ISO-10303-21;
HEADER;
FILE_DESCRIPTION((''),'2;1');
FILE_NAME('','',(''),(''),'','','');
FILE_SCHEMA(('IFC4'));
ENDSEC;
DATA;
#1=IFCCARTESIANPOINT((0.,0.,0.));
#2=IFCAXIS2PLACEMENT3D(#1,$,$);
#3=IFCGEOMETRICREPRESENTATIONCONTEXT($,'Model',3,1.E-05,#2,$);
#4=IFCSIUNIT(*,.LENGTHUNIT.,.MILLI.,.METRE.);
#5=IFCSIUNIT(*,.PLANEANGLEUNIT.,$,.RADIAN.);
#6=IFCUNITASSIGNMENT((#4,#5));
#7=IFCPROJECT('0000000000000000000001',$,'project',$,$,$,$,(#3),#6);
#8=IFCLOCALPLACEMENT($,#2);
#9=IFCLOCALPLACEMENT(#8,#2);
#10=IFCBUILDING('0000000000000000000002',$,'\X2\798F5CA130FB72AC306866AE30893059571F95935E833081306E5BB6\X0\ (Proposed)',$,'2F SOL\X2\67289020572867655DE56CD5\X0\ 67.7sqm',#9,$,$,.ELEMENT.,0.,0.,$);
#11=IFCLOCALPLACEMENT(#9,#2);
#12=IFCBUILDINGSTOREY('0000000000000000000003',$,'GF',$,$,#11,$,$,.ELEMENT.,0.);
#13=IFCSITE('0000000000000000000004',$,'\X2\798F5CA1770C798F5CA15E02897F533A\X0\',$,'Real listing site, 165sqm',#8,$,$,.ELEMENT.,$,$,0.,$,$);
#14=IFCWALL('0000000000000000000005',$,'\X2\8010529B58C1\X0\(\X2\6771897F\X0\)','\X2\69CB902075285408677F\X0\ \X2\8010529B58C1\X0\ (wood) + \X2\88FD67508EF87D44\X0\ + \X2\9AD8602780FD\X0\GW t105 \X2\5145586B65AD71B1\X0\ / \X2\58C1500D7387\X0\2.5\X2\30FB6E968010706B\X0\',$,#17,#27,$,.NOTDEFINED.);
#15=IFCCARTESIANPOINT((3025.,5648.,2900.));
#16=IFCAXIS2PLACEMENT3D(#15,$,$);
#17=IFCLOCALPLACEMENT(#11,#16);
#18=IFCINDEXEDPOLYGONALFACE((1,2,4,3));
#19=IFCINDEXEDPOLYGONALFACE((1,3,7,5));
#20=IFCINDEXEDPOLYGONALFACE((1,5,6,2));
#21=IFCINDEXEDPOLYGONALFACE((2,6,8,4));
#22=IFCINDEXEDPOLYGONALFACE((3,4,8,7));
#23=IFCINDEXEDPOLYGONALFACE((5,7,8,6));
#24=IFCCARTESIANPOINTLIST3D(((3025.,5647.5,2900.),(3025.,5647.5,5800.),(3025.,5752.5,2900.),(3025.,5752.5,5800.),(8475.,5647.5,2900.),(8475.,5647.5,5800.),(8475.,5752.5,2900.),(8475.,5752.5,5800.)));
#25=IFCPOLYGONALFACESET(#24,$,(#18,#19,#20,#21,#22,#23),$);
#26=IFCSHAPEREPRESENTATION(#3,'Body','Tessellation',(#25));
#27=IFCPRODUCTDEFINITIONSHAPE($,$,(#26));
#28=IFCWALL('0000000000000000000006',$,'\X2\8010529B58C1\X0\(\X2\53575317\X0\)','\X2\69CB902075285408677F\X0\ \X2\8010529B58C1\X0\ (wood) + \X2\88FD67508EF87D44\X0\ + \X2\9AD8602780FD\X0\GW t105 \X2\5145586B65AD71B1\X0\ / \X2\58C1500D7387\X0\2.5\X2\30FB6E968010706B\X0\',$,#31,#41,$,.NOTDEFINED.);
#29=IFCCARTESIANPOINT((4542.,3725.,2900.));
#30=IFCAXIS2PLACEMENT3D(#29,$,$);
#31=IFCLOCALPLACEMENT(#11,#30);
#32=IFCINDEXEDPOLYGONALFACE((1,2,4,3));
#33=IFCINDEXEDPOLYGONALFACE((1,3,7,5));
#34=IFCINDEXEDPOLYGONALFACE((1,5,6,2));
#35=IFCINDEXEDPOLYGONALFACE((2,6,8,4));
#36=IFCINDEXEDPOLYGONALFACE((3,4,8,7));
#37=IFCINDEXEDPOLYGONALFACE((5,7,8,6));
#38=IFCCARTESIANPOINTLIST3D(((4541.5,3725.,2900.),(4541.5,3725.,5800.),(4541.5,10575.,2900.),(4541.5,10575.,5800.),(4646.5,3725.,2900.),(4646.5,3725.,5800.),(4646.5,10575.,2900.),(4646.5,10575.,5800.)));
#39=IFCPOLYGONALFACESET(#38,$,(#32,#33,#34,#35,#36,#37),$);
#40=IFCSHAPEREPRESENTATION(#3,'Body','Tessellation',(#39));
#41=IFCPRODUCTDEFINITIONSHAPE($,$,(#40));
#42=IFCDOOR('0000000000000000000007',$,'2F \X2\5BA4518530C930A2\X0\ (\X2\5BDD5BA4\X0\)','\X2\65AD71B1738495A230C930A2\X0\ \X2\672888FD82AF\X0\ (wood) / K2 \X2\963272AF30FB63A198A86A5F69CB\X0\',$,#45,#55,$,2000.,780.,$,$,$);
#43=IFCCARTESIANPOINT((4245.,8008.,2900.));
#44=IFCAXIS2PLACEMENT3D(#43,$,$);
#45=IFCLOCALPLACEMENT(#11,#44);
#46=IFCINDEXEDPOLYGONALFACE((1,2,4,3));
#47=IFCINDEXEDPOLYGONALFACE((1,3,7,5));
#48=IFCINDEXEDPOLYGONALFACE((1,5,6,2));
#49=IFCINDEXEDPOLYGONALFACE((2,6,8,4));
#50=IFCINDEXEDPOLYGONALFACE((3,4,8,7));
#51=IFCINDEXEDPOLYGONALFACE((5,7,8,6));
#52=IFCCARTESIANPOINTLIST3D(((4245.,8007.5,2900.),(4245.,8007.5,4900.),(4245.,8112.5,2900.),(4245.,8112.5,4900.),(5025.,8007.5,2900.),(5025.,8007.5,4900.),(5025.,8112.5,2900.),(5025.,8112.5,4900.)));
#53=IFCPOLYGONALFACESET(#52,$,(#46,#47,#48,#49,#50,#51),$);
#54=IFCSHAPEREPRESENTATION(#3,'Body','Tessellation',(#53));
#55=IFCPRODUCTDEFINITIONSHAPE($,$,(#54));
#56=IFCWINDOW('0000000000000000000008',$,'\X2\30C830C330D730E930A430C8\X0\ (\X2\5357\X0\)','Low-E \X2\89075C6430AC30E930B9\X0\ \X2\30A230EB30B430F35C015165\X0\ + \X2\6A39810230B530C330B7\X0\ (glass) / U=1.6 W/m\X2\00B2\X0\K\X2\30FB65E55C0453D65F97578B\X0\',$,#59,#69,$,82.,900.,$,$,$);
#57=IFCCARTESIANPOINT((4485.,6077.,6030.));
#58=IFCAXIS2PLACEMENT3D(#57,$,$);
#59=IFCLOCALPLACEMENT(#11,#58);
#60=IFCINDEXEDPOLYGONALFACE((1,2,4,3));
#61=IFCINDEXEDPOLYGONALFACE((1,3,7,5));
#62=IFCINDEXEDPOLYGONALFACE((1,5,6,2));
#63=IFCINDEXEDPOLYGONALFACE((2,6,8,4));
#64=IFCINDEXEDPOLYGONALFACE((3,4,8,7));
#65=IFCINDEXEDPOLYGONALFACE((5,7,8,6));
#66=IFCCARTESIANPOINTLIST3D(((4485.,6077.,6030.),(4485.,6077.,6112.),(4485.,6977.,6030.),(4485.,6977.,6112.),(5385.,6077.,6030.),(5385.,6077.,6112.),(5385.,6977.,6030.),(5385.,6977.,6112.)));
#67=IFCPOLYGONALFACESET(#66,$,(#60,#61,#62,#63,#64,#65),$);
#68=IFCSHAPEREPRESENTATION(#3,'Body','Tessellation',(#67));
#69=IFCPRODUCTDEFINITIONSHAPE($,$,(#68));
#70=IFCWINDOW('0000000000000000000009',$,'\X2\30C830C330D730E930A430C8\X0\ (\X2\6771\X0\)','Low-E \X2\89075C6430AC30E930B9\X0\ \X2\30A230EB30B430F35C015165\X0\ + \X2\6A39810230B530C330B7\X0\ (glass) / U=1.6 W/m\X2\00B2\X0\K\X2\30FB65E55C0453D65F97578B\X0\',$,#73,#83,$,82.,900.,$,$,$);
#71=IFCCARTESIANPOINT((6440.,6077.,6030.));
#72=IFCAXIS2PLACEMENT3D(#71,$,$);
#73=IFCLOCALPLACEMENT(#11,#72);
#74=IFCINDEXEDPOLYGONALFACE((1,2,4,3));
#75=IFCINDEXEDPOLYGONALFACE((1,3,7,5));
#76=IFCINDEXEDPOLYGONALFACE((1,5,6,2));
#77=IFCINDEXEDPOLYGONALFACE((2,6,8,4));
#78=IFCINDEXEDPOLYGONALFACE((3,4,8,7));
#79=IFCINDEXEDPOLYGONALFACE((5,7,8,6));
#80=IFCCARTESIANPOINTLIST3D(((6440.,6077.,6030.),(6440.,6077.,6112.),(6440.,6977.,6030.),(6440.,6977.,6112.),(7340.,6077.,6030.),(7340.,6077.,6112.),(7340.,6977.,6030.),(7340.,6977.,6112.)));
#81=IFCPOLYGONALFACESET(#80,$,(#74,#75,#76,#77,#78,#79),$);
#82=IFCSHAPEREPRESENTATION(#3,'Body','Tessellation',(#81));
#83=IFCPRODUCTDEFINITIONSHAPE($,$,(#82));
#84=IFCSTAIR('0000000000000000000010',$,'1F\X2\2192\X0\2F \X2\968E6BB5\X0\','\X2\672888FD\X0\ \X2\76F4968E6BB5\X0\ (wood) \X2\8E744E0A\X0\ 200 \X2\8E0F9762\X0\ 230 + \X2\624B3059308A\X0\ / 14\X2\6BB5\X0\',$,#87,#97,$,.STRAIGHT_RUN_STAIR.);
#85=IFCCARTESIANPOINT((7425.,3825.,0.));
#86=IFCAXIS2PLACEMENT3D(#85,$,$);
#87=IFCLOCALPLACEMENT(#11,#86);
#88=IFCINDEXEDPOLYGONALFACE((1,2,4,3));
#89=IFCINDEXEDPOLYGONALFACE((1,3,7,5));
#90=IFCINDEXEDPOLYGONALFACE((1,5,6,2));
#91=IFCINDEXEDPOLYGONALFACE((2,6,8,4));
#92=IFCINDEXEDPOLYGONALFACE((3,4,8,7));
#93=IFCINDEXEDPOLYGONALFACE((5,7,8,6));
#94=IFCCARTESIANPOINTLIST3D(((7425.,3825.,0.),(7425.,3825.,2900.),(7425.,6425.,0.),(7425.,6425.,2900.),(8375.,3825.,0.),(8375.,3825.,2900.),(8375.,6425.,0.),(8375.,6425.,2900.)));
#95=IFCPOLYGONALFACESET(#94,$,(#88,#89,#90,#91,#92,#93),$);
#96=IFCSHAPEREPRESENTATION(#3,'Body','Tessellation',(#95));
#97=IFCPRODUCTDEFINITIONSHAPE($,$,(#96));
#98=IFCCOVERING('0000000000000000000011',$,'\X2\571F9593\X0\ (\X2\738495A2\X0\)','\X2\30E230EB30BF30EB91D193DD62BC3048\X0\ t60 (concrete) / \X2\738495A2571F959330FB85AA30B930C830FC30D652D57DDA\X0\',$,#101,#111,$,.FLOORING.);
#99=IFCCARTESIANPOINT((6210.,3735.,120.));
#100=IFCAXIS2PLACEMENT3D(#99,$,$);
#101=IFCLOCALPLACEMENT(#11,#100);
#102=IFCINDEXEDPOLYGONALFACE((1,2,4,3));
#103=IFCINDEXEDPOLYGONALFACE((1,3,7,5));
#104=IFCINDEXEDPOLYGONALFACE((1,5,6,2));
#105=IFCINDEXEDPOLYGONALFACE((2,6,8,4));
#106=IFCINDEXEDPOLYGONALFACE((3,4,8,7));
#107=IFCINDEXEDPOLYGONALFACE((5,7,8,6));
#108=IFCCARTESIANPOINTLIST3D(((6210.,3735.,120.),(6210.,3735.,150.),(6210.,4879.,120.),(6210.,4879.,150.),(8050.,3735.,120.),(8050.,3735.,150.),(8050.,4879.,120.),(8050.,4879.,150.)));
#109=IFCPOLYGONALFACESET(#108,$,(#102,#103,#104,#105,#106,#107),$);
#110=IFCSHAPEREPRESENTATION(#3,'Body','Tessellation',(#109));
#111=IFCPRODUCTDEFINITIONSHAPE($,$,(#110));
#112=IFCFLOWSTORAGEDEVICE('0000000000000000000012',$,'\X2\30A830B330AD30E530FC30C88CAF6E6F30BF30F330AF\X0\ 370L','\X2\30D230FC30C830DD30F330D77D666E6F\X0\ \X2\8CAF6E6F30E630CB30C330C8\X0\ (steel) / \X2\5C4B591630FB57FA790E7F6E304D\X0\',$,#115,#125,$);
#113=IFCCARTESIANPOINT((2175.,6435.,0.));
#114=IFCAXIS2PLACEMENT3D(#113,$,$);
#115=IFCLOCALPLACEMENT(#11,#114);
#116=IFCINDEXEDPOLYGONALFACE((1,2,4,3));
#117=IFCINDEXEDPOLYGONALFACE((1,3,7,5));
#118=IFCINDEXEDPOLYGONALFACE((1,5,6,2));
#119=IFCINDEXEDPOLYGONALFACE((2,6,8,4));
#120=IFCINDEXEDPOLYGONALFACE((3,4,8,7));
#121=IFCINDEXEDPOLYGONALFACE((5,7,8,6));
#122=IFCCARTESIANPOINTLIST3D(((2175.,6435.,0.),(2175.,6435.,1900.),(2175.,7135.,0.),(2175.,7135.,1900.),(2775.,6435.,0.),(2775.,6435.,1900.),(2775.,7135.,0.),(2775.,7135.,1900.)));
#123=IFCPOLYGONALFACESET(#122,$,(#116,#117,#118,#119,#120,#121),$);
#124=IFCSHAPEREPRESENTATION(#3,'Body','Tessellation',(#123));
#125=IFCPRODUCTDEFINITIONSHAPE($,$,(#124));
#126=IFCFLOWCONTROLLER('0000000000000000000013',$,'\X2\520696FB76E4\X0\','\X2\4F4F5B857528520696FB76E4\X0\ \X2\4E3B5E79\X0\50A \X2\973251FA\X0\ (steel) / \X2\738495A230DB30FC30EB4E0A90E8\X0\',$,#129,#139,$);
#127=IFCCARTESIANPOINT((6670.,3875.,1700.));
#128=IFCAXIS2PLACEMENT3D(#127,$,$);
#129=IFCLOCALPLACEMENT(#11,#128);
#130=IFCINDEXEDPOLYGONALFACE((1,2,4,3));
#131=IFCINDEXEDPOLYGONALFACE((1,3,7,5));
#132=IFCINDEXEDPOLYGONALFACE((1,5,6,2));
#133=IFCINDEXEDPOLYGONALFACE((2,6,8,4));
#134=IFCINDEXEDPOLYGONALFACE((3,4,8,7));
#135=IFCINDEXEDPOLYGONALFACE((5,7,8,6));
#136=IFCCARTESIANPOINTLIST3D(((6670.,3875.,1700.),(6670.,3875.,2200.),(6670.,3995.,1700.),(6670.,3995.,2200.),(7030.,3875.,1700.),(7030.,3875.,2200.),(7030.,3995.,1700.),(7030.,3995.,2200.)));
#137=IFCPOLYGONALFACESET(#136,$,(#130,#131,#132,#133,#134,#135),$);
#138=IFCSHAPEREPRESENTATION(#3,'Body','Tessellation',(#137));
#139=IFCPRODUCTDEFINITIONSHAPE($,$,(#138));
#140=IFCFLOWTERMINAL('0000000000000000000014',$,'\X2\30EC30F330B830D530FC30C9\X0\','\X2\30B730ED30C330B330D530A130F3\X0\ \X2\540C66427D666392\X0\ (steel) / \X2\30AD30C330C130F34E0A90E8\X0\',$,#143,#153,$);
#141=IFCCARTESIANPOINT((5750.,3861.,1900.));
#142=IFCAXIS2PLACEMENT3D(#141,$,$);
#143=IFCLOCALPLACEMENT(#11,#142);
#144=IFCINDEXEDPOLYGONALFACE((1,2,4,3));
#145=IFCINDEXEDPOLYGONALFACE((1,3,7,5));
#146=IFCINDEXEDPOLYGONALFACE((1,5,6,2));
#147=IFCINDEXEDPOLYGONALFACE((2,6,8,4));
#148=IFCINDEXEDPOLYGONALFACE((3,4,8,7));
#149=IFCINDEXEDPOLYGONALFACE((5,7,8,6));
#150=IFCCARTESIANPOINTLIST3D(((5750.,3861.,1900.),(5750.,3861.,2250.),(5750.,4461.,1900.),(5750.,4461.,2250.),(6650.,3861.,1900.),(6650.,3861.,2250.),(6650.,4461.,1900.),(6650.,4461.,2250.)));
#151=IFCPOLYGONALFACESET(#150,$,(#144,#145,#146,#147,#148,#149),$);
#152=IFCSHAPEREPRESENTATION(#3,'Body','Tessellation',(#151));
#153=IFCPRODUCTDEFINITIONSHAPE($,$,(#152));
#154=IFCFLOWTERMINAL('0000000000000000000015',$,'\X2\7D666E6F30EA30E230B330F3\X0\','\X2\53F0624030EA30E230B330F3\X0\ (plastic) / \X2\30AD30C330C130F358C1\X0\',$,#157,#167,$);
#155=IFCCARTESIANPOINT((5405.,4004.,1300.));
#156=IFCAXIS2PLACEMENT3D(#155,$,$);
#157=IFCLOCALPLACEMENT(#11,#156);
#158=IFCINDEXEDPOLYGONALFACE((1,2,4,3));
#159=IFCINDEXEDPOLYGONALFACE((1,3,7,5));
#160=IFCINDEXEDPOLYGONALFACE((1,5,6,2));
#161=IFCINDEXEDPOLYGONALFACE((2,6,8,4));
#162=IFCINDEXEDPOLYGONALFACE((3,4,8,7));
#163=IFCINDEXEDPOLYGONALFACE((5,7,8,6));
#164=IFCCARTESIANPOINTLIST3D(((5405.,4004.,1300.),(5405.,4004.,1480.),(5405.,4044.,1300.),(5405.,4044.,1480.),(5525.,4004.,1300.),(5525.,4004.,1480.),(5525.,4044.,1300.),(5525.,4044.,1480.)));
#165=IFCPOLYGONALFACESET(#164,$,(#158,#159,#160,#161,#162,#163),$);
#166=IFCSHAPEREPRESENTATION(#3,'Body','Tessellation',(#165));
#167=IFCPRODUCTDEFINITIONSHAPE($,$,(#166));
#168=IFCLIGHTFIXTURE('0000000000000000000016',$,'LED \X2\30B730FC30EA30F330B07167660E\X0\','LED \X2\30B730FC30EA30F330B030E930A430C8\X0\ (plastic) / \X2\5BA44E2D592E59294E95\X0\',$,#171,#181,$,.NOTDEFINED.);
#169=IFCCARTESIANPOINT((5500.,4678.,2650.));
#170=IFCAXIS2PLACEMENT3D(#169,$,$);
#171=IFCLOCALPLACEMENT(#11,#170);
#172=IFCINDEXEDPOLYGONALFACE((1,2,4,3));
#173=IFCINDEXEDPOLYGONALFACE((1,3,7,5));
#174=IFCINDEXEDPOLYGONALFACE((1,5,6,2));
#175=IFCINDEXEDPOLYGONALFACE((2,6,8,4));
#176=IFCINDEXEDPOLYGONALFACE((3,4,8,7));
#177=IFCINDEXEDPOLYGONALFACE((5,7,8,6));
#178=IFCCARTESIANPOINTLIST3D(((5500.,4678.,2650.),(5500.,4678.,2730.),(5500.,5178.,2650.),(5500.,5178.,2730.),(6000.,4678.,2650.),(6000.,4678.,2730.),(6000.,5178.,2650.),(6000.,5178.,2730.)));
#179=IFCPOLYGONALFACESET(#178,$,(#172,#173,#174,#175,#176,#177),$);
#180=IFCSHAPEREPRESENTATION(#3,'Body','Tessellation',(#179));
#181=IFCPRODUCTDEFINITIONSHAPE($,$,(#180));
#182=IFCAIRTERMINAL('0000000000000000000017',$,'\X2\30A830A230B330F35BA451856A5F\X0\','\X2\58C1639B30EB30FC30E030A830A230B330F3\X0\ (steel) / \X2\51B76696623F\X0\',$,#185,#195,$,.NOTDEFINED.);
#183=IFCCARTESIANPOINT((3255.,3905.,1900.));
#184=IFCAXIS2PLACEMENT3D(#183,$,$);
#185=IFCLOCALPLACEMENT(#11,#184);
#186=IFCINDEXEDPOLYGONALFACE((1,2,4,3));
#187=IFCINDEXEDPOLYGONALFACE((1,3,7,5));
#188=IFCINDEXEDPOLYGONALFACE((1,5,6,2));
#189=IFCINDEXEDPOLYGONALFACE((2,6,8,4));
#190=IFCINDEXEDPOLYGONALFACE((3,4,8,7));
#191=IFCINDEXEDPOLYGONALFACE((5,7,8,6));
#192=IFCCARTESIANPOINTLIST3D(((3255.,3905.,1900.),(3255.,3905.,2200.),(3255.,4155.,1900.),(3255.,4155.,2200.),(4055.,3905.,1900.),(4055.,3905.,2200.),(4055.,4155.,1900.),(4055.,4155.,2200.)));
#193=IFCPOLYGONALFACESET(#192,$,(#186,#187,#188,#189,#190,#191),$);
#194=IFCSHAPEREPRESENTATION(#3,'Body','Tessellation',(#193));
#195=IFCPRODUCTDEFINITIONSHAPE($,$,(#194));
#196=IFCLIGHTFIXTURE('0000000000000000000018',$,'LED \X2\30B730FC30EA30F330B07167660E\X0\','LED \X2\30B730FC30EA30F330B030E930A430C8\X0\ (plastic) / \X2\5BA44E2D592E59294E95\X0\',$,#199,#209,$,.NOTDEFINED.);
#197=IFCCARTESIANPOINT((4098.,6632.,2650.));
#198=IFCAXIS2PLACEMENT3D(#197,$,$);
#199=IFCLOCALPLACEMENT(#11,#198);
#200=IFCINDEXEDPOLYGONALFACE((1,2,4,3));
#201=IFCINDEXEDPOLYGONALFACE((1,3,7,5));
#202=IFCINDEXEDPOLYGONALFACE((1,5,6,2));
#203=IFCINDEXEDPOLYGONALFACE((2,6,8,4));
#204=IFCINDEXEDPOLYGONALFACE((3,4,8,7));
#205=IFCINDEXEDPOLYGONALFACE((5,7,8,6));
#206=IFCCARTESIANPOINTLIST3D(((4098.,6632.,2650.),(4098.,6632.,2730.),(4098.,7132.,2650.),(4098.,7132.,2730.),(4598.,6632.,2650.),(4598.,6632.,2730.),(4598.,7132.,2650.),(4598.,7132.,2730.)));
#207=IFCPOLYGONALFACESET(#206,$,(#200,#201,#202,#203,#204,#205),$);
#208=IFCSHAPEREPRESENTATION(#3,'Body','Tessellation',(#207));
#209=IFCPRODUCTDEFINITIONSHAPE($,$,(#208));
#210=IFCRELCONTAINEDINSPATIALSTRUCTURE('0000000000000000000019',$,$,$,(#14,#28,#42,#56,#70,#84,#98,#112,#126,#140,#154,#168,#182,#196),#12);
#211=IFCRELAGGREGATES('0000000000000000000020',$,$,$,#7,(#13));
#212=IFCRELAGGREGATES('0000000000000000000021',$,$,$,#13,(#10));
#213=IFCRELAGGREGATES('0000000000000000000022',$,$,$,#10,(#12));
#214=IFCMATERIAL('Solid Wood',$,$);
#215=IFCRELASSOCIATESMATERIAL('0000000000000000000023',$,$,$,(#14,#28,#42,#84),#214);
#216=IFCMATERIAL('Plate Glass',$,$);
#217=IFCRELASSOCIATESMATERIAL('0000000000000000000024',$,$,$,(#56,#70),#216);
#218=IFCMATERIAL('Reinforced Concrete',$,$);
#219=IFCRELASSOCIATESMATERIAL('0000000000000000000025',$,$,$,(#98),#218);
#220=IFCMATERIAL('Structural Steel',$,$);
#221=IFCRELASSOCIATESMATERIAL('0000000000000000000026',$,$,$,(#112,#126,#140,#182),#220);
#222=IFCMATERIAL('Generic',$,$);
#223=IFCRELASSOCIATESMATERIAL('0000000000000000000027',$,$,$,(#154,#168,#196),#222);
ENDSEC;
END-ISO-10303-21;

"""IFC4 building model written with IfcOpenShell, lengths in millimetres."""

from ifc_helpers import new_model, si_unit, frame, frame_2d, origin, place, context, project, spatial, rectangle, extrude, material, element, fill, save


model = new_model("IFC4")

# Units and contexts
model_context = context("Model", 3, precision=1e-05, world=origin())
ifc_project = project(units=[si_unit("LENGTHUNIT", "METRE", prefix="MILLI"), si_unit("PLANEANGLEUNIT", "RADIAN")], contexts=[model_context])

# Site, building, storey
site_placement = place(None, origin())
site = spatial("IfcSite", under=ifc_project, at=site_placement, Name="福岡県福岡市西区", ObjectType="Real listing site, 165sqm", CompositionType="ELEMENT", RefElevation=0.0)
building_placement = place(site_placement, origin())
building = spatial("IfcBuilding", under=site, at=building_placement, Name="福岡・犬と暮らす土間広めの家 (Proposed)", ObjectType="2F SOL木造在来工法 67.7sqm", CompositionType="ELEMENT", ElevationOfRefHeight=0.0, ElevationOfTerrain=0.0)
storey_placement = place(building_placement, origin())
storey = spatial("IfcBuildingStorey", under=building, at=storey_placement, Name="GF", CompositionType="ELEMENT", Elevation=0.0)

# Shared definitions
ifc_material_1 = material(Name="Solid Wood")

# Wall
wall_1_placement = place(storey_placement, frame((3025.0, 5648.0, 2900.0)))
element("IfcWall", 1, at=wall_1_placement, inside=storey, material=ifc_material_1, Name="耐力壁(東西)", Description="構造用合板 耐力壁 (wood) + 製材軸組 + 高性能GW t105 充填断熱 / 壁倍率2.5・準耐火", PredefinedType="NOTDEFINED", context=model_context, shape_type="SweptSolid", body=[
    extrude(rectangle(XDim=5450.0, YDim=105.0, at=frame_2d((2725.0, 52.0))), frame((3025.0, 5648.0, 2900.0)), (0.0, 0.0, 1.0), 2900.0),
])

# Wall, opening, door
wall_2_placement = place(storey_placement, frame((4542.0, 3725.0, 2900.0)))
wall_2 = element("IfcWall", 2, at=wall_2_placement, inside=storey, material=ifc_material_1, Name="耐力壁(南北)", Description="構造用合板 耐力壁 (wood) + 製材軸組 + 高性能GW t105 充填断熱 / 壁倍率2.5・準耐火", PredefinedType="NOTDEFINED", context=model_context, shape_type="SweptSolid", body=[
    extrude(rectangle(XDim=105.0, YDim=6850.0, at=frame_2d((52.0, 3425.0))), frame((4542.0, 3725.0, 2900.0)), (0.0, 0.0, 1.0), 2900.0),
])
opening_placement = place(storey_placement, frame((4245.0, 8008.0, 2900.0)))
opening = element("IfcOpeningElement", 3, at=opening_placement, cuts=wall_2, PredefinedType="NOTDEFINED", context=model_context, shape_type="SweptSolid", body=[
    extrude(rectangle(XDim=780.0, YDim=105.0, at=frame_2d((390.0, 52.0))), frame((4245.0, 8008.0, 2900.0)), (0.0, 0.0, 1.0), 2000.0),
])
door_placement = place(storey_placement, frame((4245.0, 8008.0, 2900.0)))
door = element("IfcDoor", 4, at=door_placement, inside=storey, material=ifc_material_1, Name="2F 室内ドア (寝室)", Description="断熱玄関ドア 木製芯 (wood) / K2 防犯・採風機構", OverallHeight=2000.0, OverallWidth=780.0, context=model_context, shape_type="SweptSolid", body=[
    extrude(rectangle(XDim=780.0, YDim=105.0, at=frame_2d((390.0, 52.0))), frame((4245.0, 8008.0, 2900.0)), (0.0, 0.0, 1.0), 2000.0),
])
fill(opening, door)

# Windows
ifc_material_2 = material(Name="Plate Glass")
window_1_placement = place(storey_placement, frame((4485.0, 6077.0, 6030.0)))
element("IfcWindow", 5, at=window_1_placement, inside=storey, material=ifc_material_2, Name="トップライト (南)", Description="Low-E 複層ガラス アルゴン封入 + 樹脂サッシ (glass) / U=1.6 W/m²K・日射取得型", OverallHeight=82.0, OverallWidth=900.0, context=model_context, shape_type="SweptSolid", body=[
    extrude(rectangle(XDim=900.0, YDim=900.0, at=frame_2d((450.0, 450.0))), frame((4485.0, 6077.0, 6030.0)), (0.0, 0.0, 1.0), 82.0),
])
window_2_placement = place(storey_placement, frame((6440.0, 6077.0, 6030.0)))
element("IfcWindow", 6, at=window_2_placement, inside=storey, material=ifc_material_2, Name="トップライト (東)", Description="Low-E 複層ガラス アルゴン封入 + 樹脂サッシ (glass) / U=1.6 W/m²K・日射取得型", OverallHeight=82.0, OverallWidth=900.0, context=model_context, shape_type="SweptSolid", body=[
    extrude(rectangle(XDim=900.0, YDim=900.0, at=frame_2d((450.0, 450.0))), frame((6440.0, 6077.0, 6030.0)), (0.0, 0.0, 1.0), 82.0),
])

# Stair
stair_placement = place(storey_placement, frame((7425.0, 3825.0, 0.0)))
element("IfcStair", 7, at=stair_placement, inside=storey, material=ifc_material_1, Name="1F→2F 階段", Description="木製 直階段 (wood) 蹴上 200 踏面 230 + 手すり / 14段", PredefinedType="STRAIGHT_RUN_STAIR", context=model_context, shape_type="SweptSolid", body=[
    extrude(rectangle(XDim=950.0, YDim=2600.0, at=frame_2d((475.0, 1300.0))), frame((7425.0, 3825.0, 0.0)), (0.0, 0.0, 1.0), 2900.0),
])

# Covering
ifc_material_3 = material(Name="Reinforced Concrete")
covering_placement = place(storey_placement, frame((6210.0, 3735.0, 120.0)))
element("IfcCovering", 8, at=covering_placement, inside=storey, material=ifc_material_3, Name="土間 (玄関)", Description="モルタル金鏝押え t60 (concrete) / 玄関土間・薪ストーブ動線", PredefinedType="FLOORING", context=model_context, shape_type="SweptSolid", body=[
    extrude(rectangle(XDim=1840.0, YDim=1144.0, at=frame_2d((920.0, 572.0))), frame((6210.0, 3735.0, 120.0)), (0.0, 0.0, 1.0), 30.0),
])

# Flow storage device
ifc_material_4 = material(Name="Structural Steel")
flow_storage_device_placement = place(storey_placement, frame((2175.0, 6435.0, 0.0)))
element("IfcFlowStorageDevice", 9, at=flow_storage_device_placement, inside=storey, material=ifc_material_4, Name="エコキュート貯湯タンク 370L", Description="ヒートポンプ給湯 貯湯ユニット (steel) / 屋外・基礎置き", context=model_context, shape_type="SweptSolid", body=[
    extrude(rectangle(XDim=600.0, YDim=700.0, at=frame_2d((300.0, 350.0))), frame((2175.0, 6435.0, 0.0)), (0.0, 0.0, 1.0), 1900.0),
])

# Flow controller
flow_controller_placement = place(storey_placement, frame((6670.0, 3875.0, 1700.0)))
element("IfcFlowController", 10, at=flow_controller_placement, inside=storey, material=ifc_material_4, Name="分電盤", Description="住宅用分電盤 主幹50A 露出 (steel) / 玄関ホール上部", context=model_context, shape_type="SweptSolid", body=[
    extrude(rectangle(XDim=360.0, YDim=120.0, at=frame_2d((180.0, 60.0))), frame((6670.0, 3875.0, 1700.0)), (0.0, 0.0, 1.0), 500.0),
])

# Flow terminals
flow_terminal_1_placement = place(storey_placement, frame((5750.0, 3861.0, 1900.0)))
element("IfcFlowTerminal", 11, at=flow_terminal_1_placement, inside=storey, material=ifc_material_4, Name="レンジフード", Description="シロッコファン 同時給排 (steel) / キッチン上部", context=model_context, shape_type="SweptSolid", body=[
    extrude(rectangle(XDim=900.0, YDim=600.0, at=frame_2d((450.0, 300.0))), frame((5750.0, 3861.0, 1900.0)), (0.0, 0.0, 1.0), 350.0),
])
ifc_material_5 = material(Name="Generic")
flow_terminal_2_placement = place(storey_placement, frame((5405.0, 4004.0, 1300.0)))
element("IfcFlowTerminal", 12, at=flow_terminal_2_placement, inside=storey, material=ifc_material_5, Name="給湯リモコン", Description="台所リモコン (plastic) / キッチン壁", context=model_context, shape_type="SweptSolid", body=[
    extrude(rectangle(XDim=120.0, YDim=40.0, at=frame_2d((60.0, 20.0))), frame((5405.0, 4004.0, 1300.0)), (0.0, 0.0, 1.0), 180.0),
])

# Light fixture
light_fixture_1_placement = place(storey_placement, frame((5500.0, 4678.0, 2650.0)))
element("IfcLightFixture", 13, at=light_fixture_1_placement, inside=storey, material=ifc_material_5, Name="LED シーリング照明", Description="LED シーリングライト (plastic) / 室中央天井", PredefinedType="NOTDEFINED", context=model_context, shape_type="SweptSolid", body=[
    extrude(rectangle(XDim=500.0, YDim=500.0, at=frame_2d((250.0, 250.0))), frame((5500.0, 4678.0, 2650.0)), (0.0, 0.0, 1.0), 80.0),
])

# Air terminal
air_terminal_1_placement = place(storey_placement, frame((3255.0, 3905.0, 1900.0)))
element("IfcAirTerminal", 14, at=air_terminal_1_placement, inside=storey, material=ifc_material_4, Name="エアコン室内機", Description="壁掛ルームエアコン (steel) / 冷暖房", PredefinedType="NOTDEFINED", context=model_context, shape_type="SweptSolid", body=[
    extrude(rectangle(XDim=800.0, YDim=250.0, at=frame_2d((400.0, 125.0))), frame((3255.0, 3905.0, 1900.0)), (0.0, 0.0, 1.0), 300.0),
])

# Light fixture
light_fixture_2_placement = place(storey_placement, frame((4098.0, 6632.0, 2650.0)))
element("IfcLightFixture", 15, at=light_fixture_2_placement, inside=storey, material=ifc_material_5, Name="LED シーリング照明", Description="LED シーリングライト (plastic) / 室中央天井", PredefinedType="NOTDEFINED", context=model_context, shape_type="SweptSolid", body=[
    extrude(rectangle(XDim=500.0, YDim=500.0, at=frame_2d((250.0, 250.0))), frame((4098.0, 6632.0, 2650.0)), (0.0, 0.0, 1.0), 80.0),
])

save(model, "model.ifc")
